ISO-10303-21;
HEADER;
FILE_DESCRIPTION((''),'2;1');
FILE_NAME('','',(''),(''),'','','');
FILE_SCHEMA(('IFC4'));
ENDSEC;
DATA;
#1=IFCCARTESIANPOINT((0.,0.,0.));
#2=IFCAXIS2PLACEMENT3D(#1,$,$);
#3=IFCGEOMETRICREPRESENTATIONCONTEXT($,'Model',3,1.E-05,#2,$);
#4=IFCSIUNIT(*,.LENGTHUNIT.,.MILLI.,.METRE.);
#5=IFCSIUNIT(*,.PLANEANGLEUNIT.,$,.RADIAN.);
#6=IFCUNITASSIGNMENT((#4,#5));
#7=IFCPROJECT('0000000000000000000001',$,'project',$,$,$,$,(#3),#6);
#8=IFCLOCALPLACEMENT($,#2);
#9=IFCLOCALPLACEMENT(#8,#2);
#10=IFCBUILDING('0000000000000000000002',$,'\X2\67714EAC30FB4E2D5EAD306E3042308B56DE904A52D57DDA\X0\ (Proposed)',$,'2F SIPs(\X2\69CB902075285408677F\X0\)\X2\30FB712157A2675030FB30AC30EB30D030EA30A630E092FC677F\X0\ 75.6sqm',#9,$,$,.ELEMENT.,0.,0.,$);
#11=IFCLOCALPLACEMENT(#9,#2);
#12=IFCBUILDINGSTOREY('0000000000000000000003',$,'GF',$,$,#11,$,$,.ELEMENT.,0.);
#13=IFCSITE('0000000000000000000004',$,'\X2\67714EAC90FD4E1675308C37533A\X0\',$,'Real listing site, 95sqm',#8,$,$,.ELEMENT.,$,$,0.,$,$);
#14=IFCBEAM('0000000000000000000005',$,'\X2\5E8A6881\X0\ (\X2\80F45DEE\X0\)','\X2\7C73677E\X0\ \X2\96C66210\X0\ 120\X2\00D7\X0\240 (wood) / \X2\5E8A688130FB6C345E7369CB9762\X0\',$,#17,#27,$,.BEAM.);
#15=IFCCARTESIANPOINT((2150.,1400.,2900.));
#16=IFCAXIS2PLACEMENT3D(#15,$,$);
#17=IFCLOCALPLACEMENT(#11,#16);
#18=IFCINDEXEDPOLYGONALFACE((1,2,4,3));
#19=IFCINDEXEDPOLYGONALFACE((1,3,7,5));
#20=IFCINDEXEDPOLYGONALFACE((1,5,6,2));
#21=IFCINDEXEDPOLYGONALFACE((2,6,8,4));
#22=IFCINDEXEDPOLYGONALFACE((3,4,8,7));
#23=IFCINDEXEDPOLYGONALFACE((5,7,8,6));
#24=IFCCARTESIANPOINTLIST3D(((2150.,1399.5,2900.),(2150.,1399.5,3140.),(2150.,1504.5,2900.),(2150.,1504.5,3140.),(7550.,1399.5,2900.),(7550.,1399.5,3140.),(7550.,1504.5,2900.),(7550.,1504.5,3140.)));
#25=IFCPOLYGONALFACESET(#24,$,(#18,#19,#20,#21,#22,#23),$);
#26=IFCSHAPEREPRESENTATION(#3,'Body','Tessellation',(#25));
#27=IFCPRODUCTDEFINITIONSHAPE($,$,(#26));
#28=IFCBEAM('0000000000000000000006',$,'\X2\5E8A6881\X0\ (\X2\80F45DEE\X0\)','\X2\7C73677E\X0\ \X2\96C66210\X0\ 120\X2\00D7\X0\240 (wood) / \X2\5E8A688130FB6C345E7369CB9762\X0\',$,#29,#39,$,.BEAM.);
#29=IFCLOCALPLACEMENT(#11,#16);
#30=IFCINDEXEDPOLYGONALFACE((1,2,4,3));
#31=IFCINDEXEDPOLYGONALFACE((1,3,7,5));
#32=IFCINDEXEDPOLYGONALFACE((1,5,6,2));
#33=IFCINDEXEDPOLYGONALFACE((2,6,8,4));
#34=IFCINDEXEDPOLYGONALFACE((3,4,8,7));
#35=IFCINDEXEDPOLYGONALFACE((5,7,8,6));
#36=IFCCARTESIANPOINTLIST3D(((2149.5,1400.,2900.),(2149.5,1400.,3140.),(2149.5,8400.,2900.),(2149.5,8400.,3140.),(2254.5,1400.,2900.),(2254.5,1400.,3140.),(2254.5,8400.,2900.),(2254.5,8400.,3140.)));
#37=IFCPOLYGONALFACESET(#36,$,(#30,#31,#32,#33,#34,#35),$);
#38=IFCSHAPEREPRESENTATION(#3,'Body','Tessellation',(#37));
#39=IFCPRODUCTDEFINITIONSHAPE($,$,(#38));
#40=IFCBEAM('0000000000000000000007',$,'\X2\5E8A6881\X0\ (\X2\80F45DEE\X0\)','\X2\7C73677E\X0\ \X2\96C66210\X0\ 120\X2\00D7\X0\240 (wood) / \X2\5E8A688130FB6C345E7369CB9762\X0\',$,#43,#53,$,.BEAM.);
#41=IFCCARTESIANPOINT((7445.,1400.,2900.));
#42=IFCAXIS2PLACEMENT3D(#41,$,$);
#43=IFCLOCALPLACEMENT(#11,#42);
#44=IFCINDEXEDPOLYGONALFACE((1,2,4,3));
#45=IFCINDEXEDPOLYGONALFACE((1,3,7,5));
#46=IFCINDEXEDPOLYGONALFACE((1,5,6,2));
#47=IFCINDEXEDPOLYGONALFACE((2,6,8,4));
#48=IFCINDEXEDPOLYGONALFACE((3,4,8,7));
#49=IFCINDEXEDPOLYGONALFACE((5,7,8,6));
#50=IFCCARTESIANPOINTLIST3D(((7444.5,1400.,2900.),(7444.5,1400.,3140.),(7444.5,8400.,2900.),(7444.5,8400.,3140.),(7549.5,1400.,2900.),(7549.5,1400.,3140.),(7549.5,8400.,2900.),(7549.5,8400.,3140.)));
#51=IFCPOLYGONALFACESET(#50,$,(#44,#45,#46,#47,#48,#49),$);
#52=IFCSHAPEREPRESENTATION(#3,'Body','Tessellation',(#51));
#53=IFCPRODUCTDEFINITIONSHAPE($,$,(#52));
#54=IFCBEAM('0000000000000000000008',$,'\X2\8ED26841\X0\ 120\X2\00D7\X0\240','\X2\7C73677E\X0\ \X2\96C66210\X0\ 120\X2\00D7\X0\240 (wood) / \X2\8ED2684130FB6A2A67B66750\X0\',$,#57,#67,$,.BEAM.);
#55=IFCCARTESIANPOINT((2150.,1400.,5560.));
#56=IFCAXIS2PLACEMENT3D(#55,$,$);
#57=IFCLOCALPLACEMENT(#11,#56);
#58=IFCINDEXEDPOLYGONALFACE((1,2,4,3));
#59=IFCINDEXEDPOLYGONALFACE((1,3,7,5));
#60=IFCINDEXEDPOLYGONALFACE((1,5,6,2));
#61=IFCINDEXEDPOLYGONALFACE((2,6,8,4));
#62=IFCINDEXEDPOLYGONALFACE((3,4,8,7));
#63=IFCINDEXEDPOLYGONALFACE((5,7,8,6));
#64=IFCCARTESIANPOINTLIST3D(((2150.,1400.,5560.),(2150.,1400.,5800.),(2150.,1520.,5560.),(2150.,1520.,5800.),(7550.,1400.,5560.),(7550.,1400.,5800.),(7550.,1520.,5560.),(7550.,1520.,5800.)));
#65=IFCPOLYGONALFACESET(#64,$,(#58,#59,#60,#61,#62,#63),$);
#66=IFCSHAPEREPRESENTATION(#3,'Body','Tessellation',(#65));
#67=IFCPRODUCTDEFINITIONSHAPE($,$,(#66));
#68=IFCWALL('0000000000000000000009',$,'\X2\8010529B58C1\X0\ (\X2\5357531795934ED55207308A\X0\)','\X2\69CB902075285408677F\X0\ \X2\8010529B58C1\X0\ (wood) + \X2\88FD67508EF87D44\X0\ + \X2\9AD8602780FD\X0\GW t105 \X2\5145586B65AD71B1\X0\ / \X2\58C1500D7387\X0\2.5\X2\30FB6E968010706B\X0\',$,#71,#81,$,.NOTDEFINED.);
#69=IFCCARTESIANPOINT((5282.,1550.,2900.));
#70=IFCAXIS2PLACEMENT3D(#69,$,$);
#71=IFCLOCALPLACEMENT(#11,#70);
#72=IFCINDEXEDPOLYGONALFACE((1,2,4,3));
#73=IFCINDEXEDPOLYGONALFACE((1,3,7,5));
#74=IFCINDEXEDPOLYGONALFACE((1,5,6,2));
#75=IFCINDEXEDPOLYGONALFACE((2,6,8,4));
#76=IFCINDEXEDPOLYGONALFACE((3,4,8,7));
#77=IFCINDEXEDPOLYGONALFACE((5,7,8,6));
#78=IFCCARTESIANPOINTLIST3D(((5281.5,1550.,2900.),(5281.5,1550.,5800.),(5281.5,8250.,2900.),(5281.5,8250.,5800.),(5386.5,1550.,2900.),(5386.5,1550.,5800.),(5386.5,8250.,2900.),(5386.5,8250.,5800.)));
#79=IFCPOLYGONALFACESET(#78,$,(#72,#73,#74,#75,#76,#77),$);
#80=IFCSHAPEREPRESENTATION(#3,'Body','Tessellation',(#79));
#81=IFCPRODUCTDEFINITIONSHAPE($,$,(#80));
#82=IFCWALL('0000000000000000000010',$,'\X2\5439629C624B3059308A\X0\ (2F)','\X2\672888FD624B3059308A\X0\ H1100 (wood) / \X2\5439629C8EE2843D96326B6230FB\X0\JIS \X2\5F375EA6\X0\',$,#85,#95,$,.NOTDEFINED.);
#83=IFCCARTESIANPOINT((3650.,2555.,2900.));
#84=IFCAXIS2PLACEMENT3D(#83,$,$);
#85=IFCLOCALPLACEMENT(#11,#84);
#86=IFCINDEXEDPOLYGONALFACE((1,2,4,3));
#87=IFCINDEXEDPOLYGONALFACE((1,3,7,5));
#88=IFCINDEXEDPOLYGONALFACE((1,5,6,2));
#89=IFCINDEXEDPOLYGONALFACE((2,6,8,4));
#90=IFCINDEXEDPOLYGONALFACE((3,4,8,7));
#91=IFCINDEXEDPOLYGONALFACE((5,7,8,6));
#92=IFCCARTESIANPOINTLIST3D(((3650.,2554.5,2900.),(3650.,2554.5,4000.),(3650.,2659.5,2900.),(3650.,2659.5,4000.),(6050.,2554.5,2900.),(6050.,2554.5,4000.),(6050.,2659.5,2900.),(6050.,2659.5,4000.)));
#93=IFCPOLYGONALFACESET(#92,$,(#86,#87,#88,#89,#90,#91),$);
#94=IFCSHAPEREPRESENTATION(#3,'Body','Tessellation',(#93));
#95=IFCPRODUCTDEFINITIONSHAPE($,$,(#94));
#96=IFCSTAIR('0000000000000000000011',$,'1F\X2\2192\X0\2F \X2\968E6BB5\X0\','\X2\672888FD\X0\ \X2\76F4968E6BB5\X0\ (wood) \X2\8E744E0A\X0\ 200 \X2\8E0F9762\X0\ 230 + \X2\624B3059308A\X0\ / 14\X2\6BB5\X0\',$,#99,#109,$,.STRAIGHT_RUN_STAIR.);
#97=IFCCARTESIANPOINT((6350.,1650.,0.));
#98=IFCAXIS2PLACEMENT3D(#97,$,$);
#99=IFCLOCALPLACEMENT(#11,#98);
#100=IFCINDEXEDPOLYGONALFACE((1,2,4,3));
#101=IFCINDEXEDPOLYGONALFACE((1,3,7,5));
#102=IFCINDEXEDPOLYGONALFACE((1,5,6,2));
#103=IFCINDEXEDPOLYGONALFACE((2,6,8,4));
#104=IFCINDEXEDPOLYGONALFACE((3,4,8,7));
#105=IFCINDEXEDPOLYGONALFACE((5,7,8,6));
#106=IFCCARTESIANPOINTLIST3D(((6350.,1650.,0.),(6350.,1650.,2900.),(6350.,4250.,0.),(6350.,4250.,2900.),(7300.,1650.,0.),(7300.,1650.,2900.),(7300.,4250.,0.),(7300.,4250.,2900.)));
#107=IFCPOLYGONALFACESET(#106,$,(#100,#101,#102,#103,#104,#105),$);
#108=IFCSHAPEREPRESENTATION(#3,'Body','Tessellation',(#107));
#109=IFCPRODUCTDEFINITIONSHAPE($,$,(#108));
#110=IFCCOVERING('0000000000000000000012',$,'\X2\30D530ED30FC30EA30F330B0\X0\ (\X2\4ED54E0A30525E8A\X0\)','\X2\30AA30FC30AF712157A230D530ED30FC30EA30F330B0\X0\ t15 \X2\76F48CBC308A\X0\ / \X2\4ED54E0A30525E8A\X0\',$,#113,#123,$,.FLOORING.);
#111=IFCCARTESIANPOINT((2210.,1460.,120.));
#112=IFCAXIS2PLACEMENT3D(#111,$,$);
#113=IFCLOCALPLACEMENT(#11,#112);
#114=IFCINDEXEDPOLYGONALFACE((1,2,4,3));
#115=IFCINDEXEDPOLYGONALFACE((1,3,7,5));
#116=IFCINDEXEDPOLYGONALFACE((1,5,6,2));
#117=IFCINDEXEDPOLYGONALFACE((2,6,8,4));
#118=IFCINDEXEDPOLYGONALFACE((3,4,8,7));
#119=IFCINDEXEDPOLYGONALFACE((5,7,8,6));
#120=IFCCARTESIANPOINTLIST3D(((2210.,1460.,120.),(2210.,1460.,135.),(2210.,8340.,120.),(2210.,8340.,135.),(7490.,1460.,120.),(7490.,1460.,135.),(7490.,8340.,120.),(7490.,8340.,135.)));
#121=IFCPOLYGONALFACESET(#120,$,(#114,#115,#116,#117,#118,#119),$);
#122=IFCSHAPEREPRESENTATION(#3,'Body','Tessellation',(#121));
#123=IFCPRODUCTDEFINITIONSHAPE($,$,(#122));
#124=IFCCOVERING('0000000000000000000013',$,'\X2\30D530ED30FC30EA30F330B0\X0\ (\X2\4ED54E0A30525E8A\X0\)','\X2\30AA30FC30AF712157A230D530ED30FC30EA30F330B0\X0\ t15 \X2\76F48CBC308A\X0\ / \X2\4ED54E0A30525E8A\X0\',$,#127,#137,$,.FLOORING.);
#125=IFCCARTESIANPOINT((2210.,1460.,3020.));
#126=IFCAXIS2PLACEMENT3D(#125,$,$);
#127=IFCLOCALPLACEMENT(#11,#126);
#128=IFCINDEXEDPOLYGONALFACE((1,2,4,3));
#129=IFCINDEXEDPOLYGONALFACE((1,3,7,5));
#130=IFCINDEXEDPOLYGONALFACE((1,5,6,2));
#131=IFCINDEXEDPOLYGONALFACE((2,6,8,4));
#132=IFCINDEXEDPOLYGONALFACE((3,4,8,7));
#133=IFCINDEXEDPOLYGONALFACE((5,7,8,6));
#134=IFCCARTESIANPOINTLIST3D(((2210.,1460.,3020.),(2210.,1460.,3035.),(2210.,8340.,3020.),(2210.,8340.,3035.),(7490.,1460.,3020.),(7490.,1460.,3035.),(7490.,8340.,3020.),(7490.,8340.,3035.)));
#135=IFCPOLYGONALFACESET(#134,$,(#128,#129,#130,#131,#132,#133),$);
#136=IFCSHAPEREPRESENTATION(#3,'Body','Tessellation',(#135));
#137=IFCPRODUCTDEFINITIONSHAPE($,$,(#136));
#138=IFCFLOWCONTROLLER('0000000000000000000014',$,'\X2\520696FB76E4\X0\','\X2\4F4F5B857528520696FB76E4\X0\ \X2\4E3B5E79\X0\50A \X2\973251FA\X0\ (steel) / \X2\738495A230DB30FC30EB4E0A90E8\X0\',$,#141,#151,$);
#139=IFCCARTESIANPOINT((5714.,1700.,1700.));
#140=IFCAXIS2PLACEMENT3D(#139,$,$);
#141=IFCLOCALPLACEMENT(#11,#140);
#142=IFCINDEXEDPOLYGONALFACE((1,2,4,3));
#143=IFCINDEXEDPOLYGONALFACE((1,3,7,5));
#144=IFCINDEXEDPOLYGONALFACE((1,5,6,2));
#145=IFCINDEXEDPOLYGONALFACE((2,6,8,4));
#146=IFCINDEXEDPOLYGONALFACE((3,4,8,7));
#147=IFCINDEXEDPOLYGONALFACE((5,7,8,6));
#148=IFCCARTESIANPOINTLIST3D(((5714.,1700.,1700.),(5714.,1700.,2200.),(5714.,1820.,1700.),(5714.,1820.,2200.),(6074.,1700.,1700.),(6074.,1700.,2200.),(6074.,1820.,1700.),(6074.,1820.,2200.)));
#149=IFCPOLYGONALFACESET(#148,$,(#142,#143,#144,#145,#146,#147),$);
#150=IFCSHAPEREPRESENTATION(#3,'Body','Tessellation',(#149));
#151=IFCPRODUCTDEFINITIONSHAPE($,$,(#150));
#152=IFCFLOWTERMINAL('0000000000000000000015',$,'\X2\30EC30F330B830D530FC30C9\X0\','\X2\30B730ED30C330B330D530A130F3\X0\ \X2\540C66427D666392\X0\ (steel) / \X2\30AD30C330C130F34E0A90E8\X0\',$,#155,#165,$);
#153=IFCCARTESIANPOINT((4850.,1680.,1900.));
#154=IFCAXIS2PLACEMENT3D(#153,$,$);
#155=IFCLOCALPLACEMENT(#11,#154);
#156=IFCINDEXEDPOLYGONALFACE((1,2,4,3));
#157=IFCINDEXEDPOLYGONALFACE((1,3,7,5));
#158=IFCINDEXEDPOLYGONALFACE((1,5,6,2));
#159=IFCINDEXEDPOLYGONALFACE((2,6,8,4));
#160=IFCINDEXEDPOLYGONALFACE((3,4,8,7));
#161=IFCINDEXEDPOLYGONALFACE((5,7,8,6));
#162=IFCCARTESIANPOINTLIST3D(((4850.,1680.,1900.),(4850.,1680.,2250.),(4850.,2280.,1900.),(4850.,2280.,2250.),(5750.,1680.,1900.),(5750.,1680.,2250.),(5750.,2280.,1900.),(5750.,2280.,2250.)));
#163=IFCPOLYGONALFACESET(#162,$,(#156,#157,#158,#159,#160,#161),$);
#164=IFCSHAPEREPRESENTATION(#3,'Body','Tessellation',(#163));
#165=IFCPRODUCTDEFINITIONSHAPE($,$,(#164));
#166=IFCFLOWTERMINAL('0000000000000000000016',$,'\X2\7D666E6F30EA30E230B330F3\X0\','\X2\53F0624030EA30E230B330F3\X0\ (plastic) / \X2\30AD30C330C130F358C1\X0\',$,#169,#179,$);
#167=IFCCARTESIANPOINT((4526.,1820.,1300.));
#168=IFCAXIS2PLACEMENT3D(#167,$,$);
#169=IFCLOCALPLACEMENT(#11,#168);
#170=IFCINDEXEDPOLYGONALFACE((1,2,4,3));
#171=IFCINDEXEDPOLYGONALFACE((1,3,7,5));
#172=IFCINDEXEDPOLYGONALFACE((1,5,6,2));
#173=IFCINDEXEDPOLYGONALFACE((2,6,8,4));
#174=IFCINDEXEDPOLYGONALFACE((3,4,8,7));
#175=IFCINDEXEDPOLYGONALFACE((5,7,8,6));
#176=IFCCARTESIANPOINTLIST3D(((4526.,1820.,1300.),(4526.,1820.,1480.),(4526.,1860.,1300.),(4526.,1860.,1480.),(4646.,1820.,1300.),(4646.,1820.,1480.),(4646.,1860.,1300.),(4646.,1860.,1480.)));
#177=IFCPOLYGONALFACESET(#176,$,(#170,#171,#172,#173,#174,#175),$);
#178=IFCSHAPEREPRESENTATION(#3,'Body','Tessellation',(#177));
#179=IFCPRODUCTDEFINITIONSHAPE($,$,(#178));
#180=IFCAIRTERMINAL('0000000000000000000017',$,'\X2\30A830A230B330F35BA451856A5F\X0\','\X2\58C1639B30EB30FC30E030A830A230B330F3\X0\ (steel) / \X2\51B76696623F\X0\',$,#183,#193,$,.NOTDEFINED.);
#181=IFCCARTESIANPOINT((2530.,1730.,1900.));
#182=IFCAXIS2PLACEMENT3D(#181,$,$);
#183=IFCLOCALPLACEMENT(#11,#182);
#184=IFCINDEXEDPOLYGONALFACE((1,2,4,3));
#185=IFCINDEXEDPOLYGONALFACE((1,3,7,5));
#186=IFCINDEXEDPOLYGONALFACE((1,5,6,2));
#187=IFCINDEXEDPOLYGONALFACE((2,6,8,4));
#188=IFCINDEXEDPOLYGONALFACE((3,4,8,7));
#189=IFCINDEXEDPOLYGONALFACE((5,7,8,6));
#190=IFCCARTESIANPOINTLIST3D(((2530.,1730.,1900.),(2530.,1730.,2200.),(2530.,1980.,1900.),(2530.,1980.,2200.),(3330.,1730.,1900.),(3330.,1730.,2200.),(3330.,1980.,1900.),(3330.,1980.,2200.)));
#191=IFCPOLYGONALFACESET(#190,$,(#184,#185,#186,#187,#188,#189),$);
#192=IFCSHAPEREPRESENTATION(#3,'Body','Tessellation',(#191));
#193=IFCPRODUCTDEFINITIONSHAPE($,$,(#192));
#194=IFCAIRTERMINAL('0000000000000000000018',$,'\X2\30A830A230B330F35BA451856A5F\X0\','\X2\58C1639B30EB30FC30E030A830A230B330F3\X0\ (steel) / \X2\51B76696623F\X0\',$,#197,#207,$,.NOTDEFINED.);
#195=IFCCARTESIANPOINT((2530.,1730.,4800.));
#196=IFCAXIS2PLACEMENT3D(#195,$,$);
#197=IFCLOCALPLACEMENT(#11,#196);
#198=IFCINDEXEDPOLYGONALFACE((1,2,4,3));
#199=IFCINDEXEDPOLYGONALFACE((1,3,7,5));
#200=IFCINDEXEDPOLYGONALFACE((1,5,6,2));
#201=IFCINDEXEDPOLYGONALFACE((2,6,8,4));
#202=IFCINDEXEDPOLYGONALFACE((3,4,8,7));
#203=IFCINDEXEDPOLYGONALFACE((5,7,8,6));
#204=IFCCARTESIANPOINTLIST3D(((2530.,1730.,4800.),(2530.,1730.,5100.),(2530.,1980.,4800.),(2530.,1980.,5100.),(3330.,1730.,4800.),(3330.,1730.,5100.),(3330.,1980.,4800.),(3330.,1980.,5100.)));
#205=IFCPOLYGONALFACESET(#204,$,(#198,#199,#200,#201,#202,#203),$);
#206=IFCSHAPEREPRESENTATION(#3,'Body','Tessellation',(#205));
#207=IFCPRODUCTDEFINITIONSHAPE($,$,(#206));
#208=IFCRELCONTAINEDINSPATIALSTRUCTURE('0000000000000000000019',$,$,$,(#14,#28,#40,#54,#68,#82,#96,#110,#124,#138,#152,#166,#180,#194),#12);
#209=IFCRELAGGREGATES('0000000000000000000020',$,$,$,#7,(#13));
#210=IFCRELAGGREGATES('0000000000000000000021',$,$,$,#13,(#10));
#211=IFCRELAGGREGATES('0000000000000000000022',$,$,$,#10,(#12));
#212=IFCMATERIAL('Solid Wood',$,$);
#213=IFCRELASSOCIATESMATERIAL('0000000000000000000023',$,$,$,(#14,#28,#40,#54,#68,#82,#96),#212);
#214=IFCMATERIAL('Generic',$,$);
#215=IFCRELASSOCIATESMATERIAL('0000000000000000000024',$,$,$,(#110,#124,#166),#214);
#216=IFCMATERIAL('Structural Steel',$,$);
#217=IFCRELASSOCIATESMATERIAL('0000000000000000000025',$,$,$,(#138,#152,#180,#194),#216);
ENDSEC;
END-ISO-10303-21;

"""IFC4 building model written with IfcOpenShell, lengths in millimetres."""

from ifc_helpers import new_model, si_unit, frame, frame_2d, origin, place, context, project, spatial, rectangle, extrude, material, element, save


model = new_model("IFC4")

# Units and contexts
model_context = context("Model", 3, precision=1e-05, world=origin())
ifc_project = project(units=[si_unit("LENGTHUNIT", "METRE", prefix="MILLI"), si_unit("PLANEANGLEUNIT", "RADIAN")], contexts=[model_context])

# Site, building, storey
site_placement = place(None, origin())
site = spatial("IfcSite", under=ifc_project, at=site_placement, Name="東京都世田谷区", ObjectType="Real listing site, 95sqm", CompositionType="ELEMENT", RefElevation=0.0)
building_placement = place(site_placement, origin())
building = spatial("IfcBuilding", under=site, at=building_placement, Name="東京・中庭のある回遊動線 (Proposed)", ObjectType="2F SIPs(構造用合板)・無垢材・ガルバリウム鋼板 75.6sqm", CompositionType="ELEMENT", ElevationOfRefHeight=0.0, ElevationOfTerrain=0.0)
storey_placement = place(building_placement, origin())
storey = spatial("IfcBuildingStorey", under=building, at=storey_placement, Name="GF", CompositionType="ELEMENT", Elevation=0.0)

# Shared definitions
ifc_material_1 = material(Name="Solid Wood")

# Beams
beam_1_placement = place(storey_placement, frame((2150.0, 1400.0, 2900.0)))
element("IfcBeam", 1, at=beam_1_placement, inside=storey, material=ifc_material_1, Name="床梁 (胴差)", Description="米松 集成 120×240 (wood) / 床梁・水平構面", PredefinedType="BEAM", context=model_context, shape_type="SweptSolid", body=[
    extrude(rectangle(XDim=5400.0, YDim=105.0, at=frame_2d((2700.0, 52.0))), frame((2150.0, 1400.0, 2900.0)), (0.0, 0.0, 1.0), 240.0),
])
beam_2_placement = place(storey_placement, frame((2150.0, 1400.0, 2900.0)))
element("IfcBeam", 2, at=beam_2_placement, inside=storey, material=ifc_material_1, Name="床梁 (胴差)", Description="米松 集成 120×240 (wood) / 床梁・水平構面", PredefinedType="BEAM", context=model_context, shape_type="SweptSolid", body=[
    extrude(rectangle(XDim=105.0, YDim=7000.0, at=frame_2d((52.0, 3500.0))), frame((2150.0, 1400.0, 2900.0)), (0.0, 0.0, 1.0), 240.0),
])
beam_3_placement = place(storey_placement, frame((7445.0, 1400.0, 2900.0)))
element("IfcBeam", 3, at=beam_3_placement, inside=storey, material=ifc_material_1, Name="床梁 (胴差)", Description="米松 集成 120×240 (wood) / 床梁・水平構面", PredefinedType="BEAM", context=model_context, shape_type="SweptSolid", body=[
    extrude(rectangle(XDim=105.0, YDim=7000.0, at=frame_2d((52.0, 3500.0))), frame((7445.0, 1400.0, 2900.0)), (0.0, 0.0, 1.0), 240.0),
])
beam_4_placement = place(storey_placement, frame((2150.0, 1400.0, 5560.0)))
element("IfcBeam", 4, at=beam_4_placement, inside=storey, material=ifc_material_1, Name="軒桁 120×240", Description="米松 集成 120×240 (wood) / 軒桁・横架材", PredefinedType="BEAM", context=model_context, shape_type="SweptSolid", body=[
    extrude(rectangle(XDim=5400.0, YDim=120.0, at=frame_2d((2700.0, 60.0))), frame((2150.0, 1400.0, 5560.0)), (0.0, 0.0, 1.0), 240.0),
])

# Walls
wall_1_placement = place(storey_placement, frame((5282.0, 1550.0, 2900.0)))
element("IfcWall", 5, at=wall_1_placement, inside=storey, material=ifc_material_1, Name="耐力壁 (南北間仕切り)", Description="構造用合板 耐力壁 (wood) + 製材軸組 + 高性能GW t105 充填断熱 / 壁倍率2.5・準耐火", PredefinedType="NOTDEFINED", context=model_context, shape_type="SweptSolid", body=[
    extrude(rectangle(XDim=105.0, YDim=6700.0, at=frame_2d((52.0, 3350.0))), frame((5282.0, 1550.0, 2900.0)), (0.0, 0.0, 1.0), 2900.0),
])
wall_2_placement = place(storey_placement, frame((3650.0, 2555.0, 2900.0)))
element("IfcWall", 6, at=wall_2_placement, inside=storey, material=ifc_material_1, Name="吹抜手すり (2F)", Description="木製手すり H1100 (wood) / 吹抜転落防止・JIS 強度", PredefinedType="NOTDEFINED", context=model_context, shape_type="SweptSolid", body=[
    extrude(rectangle(XDim=2400.0, YDim=105.0, at=frame_2d((1200.0, 52.0))), frame((3650.0, 2555.0, 2900.0)), (0.0, 0.0, 1.0), 1100.0),
])

# Stair
stair_placement = place(storey_placement, frame((6350.0, 1650.0, 0.0)))
element("IfcStair", 7, at=stair_placement, inside=storey, material=ifc_material_1, Name="1F→2F 階段", Description="木製 直階段 (wood) 蹴上 200 踏面 230 + 手すり / 14段", PredefinedType="STRAIGHT_RUN_STAIR", context=model_context, shape_type="SweptSolid", body=[
    extrude(rectangle(XDim=950.0, YDim=2600.0, at=frame_2d((475.0, 1300.0))), frame((6350.0, 1650.0, 0.0)), (0.0, 0.0, 1.0), 2900.0),
])

# Coverings
ifc_material_2 = material(Name="Generic")
covering_1_placement = place(storey_placement, frame((2210.0, 1460.0, 120.0)))
element("IfcCovering", 8, at=covering_1_placement, inside=storey, material=ifc_material_2, Name="フローリング (仕上げ床)", Description="オーク無垢フローリング t15 直貼り / 仕上げ床", PredefinedType="FLOORING", context=model_context, shape_type="SweptSolid", body=[
    extrude(rectangle(XDim=5280.0, YDim=6880.0, at=frame_2d((2640.0, 3440.0))), frame((2210.0, 1460.0, 120.0)), (0.0, 0.0, 1.0), 15.0),
])
covering_2_placement = place(storey_placement, frame((2210.0, 1460.0, 3020.0)))
element("IfcCovering", 9, at=covering_2_placement, inside=storey, material=ifc_material_2, Name="フローリング (仕上げ床)", Description="オーク無垢フローリング t15 直貼り / 仕上げ床", PredefinedType="FLOORING", context=model_context, shape_type="SweptSolid", body=[
    extrude(rectangle(XDim=5280.0, YDim=6880.0, at=frame_2d((2640.0, 3440.0))), frame((2210.0, 1460.0, 3020.0)), (0.0, 0.0, 1.0), 15.0),
])

# Flow controller
ifc_material_3 = material(Name="Structural Steel")
flow_controller_placement = place(storey_placement, frame((5714.0, 1700.0, 1700.0)))
element("IfcFlowController", 10, at=flow_controller_placement, inside=storey, material=ifc_material_3, Name="分電盤", Description="住宅用分電盤 主幹50A 露出 (steel) / 玄関ホール上部", context=model_context, shape_type="SweptSolid", body=[
    extrude(rectangle(XDim=360.0, YDim=120.0, at=frame_2d((180.0, 60.0))), frame((5714.0, 1700.0, 1700.0)), (0.0, 0.0, 1.0), 500.0),
])

# Flow terminals
flow_terminal_1_placement = place(storey_placement, frame((4850.0, 1680.0, 1900.0)))
element("IfcFlowTerminal", 11, at=flow_terminal_1_placement, inside=storey, material=ifc_material_3, Name="レンジフード", Description="シロッコファン 同時給排 (steel) / キッチン上部", context=model_context, shape_type="SweptSolid", body=[
    extrude(rectangle(XDim=900.0, YDim=600.0, at=frame_2d((450.0, 300.0))), frame((4850.0, 1680.0, 1900.0)), (0.0, 0.0, 1.0), 350.0),
])
flow_terminal_2_placement = place(storey_placement, frame((4526.0, 1820.0, 1300.0)))
element("IfcFlowTerminal", 12, at=flow_terminal_2_placement, inside=storey, material=ifc_material_2, Name="給湯リモコン", Description="台所リモコン (plastic) / キッチン壁", context=model_context, shape_type="SweptSolid", body=[
    extrude(rectangle(XDim=120.0, YDim=40.0, at=frame_2d((60.0, 20.0))), frame((4526.0, 1820.0, 1300.0)), (0.0, 0.0, 1.0), 180.0),
])

# Air terminals
air_terminal_1_placement = place(storey_placement, frame((2530.0, 1730.0, 1900.0)))
element("IfcAirTerminal", 13, at=air_terminal_1_placement, inside=storey, material=ifc_material_3, Name="エアコン室内機", Description="壁掛ルームエアコン (steel) / 冷暖房", PredefinedType="NOTDEFINED", context=model_context, shape_type="SweptSolid", body=[
    extrude(rectangle(XDim=800.0, YDim=250.0, at=frame_2d((400.0, 125.0))), frame((2530.0, 1730.0, 1900.0)), (0.0, 0.0, 1.0), 300.0),
])
air_terminal_2_placement = place(storey_placement, frame((2530.0, 1730.0, 4800.0)))
element("IfcAirTerminal", 14, at=air_terminal_2_placement, inside=storey, material=ifc_material_3, Name="エアコン室内機", Description="壁掛ルームエアコン (steel) / 冷暖房", PredefinedType="NOTDEFINED", context=model_context, shape_type="SweptSolid", body=[
    extrude(rectangle(XDim=800.0, YDim=250.0, at=frame_2d((400.0, 125.0))), frame((2530.0, 1730.0, 4800.0)), (0.0, 0.0, 1.0), 300.0),
])

save(model, "model.ifc")
